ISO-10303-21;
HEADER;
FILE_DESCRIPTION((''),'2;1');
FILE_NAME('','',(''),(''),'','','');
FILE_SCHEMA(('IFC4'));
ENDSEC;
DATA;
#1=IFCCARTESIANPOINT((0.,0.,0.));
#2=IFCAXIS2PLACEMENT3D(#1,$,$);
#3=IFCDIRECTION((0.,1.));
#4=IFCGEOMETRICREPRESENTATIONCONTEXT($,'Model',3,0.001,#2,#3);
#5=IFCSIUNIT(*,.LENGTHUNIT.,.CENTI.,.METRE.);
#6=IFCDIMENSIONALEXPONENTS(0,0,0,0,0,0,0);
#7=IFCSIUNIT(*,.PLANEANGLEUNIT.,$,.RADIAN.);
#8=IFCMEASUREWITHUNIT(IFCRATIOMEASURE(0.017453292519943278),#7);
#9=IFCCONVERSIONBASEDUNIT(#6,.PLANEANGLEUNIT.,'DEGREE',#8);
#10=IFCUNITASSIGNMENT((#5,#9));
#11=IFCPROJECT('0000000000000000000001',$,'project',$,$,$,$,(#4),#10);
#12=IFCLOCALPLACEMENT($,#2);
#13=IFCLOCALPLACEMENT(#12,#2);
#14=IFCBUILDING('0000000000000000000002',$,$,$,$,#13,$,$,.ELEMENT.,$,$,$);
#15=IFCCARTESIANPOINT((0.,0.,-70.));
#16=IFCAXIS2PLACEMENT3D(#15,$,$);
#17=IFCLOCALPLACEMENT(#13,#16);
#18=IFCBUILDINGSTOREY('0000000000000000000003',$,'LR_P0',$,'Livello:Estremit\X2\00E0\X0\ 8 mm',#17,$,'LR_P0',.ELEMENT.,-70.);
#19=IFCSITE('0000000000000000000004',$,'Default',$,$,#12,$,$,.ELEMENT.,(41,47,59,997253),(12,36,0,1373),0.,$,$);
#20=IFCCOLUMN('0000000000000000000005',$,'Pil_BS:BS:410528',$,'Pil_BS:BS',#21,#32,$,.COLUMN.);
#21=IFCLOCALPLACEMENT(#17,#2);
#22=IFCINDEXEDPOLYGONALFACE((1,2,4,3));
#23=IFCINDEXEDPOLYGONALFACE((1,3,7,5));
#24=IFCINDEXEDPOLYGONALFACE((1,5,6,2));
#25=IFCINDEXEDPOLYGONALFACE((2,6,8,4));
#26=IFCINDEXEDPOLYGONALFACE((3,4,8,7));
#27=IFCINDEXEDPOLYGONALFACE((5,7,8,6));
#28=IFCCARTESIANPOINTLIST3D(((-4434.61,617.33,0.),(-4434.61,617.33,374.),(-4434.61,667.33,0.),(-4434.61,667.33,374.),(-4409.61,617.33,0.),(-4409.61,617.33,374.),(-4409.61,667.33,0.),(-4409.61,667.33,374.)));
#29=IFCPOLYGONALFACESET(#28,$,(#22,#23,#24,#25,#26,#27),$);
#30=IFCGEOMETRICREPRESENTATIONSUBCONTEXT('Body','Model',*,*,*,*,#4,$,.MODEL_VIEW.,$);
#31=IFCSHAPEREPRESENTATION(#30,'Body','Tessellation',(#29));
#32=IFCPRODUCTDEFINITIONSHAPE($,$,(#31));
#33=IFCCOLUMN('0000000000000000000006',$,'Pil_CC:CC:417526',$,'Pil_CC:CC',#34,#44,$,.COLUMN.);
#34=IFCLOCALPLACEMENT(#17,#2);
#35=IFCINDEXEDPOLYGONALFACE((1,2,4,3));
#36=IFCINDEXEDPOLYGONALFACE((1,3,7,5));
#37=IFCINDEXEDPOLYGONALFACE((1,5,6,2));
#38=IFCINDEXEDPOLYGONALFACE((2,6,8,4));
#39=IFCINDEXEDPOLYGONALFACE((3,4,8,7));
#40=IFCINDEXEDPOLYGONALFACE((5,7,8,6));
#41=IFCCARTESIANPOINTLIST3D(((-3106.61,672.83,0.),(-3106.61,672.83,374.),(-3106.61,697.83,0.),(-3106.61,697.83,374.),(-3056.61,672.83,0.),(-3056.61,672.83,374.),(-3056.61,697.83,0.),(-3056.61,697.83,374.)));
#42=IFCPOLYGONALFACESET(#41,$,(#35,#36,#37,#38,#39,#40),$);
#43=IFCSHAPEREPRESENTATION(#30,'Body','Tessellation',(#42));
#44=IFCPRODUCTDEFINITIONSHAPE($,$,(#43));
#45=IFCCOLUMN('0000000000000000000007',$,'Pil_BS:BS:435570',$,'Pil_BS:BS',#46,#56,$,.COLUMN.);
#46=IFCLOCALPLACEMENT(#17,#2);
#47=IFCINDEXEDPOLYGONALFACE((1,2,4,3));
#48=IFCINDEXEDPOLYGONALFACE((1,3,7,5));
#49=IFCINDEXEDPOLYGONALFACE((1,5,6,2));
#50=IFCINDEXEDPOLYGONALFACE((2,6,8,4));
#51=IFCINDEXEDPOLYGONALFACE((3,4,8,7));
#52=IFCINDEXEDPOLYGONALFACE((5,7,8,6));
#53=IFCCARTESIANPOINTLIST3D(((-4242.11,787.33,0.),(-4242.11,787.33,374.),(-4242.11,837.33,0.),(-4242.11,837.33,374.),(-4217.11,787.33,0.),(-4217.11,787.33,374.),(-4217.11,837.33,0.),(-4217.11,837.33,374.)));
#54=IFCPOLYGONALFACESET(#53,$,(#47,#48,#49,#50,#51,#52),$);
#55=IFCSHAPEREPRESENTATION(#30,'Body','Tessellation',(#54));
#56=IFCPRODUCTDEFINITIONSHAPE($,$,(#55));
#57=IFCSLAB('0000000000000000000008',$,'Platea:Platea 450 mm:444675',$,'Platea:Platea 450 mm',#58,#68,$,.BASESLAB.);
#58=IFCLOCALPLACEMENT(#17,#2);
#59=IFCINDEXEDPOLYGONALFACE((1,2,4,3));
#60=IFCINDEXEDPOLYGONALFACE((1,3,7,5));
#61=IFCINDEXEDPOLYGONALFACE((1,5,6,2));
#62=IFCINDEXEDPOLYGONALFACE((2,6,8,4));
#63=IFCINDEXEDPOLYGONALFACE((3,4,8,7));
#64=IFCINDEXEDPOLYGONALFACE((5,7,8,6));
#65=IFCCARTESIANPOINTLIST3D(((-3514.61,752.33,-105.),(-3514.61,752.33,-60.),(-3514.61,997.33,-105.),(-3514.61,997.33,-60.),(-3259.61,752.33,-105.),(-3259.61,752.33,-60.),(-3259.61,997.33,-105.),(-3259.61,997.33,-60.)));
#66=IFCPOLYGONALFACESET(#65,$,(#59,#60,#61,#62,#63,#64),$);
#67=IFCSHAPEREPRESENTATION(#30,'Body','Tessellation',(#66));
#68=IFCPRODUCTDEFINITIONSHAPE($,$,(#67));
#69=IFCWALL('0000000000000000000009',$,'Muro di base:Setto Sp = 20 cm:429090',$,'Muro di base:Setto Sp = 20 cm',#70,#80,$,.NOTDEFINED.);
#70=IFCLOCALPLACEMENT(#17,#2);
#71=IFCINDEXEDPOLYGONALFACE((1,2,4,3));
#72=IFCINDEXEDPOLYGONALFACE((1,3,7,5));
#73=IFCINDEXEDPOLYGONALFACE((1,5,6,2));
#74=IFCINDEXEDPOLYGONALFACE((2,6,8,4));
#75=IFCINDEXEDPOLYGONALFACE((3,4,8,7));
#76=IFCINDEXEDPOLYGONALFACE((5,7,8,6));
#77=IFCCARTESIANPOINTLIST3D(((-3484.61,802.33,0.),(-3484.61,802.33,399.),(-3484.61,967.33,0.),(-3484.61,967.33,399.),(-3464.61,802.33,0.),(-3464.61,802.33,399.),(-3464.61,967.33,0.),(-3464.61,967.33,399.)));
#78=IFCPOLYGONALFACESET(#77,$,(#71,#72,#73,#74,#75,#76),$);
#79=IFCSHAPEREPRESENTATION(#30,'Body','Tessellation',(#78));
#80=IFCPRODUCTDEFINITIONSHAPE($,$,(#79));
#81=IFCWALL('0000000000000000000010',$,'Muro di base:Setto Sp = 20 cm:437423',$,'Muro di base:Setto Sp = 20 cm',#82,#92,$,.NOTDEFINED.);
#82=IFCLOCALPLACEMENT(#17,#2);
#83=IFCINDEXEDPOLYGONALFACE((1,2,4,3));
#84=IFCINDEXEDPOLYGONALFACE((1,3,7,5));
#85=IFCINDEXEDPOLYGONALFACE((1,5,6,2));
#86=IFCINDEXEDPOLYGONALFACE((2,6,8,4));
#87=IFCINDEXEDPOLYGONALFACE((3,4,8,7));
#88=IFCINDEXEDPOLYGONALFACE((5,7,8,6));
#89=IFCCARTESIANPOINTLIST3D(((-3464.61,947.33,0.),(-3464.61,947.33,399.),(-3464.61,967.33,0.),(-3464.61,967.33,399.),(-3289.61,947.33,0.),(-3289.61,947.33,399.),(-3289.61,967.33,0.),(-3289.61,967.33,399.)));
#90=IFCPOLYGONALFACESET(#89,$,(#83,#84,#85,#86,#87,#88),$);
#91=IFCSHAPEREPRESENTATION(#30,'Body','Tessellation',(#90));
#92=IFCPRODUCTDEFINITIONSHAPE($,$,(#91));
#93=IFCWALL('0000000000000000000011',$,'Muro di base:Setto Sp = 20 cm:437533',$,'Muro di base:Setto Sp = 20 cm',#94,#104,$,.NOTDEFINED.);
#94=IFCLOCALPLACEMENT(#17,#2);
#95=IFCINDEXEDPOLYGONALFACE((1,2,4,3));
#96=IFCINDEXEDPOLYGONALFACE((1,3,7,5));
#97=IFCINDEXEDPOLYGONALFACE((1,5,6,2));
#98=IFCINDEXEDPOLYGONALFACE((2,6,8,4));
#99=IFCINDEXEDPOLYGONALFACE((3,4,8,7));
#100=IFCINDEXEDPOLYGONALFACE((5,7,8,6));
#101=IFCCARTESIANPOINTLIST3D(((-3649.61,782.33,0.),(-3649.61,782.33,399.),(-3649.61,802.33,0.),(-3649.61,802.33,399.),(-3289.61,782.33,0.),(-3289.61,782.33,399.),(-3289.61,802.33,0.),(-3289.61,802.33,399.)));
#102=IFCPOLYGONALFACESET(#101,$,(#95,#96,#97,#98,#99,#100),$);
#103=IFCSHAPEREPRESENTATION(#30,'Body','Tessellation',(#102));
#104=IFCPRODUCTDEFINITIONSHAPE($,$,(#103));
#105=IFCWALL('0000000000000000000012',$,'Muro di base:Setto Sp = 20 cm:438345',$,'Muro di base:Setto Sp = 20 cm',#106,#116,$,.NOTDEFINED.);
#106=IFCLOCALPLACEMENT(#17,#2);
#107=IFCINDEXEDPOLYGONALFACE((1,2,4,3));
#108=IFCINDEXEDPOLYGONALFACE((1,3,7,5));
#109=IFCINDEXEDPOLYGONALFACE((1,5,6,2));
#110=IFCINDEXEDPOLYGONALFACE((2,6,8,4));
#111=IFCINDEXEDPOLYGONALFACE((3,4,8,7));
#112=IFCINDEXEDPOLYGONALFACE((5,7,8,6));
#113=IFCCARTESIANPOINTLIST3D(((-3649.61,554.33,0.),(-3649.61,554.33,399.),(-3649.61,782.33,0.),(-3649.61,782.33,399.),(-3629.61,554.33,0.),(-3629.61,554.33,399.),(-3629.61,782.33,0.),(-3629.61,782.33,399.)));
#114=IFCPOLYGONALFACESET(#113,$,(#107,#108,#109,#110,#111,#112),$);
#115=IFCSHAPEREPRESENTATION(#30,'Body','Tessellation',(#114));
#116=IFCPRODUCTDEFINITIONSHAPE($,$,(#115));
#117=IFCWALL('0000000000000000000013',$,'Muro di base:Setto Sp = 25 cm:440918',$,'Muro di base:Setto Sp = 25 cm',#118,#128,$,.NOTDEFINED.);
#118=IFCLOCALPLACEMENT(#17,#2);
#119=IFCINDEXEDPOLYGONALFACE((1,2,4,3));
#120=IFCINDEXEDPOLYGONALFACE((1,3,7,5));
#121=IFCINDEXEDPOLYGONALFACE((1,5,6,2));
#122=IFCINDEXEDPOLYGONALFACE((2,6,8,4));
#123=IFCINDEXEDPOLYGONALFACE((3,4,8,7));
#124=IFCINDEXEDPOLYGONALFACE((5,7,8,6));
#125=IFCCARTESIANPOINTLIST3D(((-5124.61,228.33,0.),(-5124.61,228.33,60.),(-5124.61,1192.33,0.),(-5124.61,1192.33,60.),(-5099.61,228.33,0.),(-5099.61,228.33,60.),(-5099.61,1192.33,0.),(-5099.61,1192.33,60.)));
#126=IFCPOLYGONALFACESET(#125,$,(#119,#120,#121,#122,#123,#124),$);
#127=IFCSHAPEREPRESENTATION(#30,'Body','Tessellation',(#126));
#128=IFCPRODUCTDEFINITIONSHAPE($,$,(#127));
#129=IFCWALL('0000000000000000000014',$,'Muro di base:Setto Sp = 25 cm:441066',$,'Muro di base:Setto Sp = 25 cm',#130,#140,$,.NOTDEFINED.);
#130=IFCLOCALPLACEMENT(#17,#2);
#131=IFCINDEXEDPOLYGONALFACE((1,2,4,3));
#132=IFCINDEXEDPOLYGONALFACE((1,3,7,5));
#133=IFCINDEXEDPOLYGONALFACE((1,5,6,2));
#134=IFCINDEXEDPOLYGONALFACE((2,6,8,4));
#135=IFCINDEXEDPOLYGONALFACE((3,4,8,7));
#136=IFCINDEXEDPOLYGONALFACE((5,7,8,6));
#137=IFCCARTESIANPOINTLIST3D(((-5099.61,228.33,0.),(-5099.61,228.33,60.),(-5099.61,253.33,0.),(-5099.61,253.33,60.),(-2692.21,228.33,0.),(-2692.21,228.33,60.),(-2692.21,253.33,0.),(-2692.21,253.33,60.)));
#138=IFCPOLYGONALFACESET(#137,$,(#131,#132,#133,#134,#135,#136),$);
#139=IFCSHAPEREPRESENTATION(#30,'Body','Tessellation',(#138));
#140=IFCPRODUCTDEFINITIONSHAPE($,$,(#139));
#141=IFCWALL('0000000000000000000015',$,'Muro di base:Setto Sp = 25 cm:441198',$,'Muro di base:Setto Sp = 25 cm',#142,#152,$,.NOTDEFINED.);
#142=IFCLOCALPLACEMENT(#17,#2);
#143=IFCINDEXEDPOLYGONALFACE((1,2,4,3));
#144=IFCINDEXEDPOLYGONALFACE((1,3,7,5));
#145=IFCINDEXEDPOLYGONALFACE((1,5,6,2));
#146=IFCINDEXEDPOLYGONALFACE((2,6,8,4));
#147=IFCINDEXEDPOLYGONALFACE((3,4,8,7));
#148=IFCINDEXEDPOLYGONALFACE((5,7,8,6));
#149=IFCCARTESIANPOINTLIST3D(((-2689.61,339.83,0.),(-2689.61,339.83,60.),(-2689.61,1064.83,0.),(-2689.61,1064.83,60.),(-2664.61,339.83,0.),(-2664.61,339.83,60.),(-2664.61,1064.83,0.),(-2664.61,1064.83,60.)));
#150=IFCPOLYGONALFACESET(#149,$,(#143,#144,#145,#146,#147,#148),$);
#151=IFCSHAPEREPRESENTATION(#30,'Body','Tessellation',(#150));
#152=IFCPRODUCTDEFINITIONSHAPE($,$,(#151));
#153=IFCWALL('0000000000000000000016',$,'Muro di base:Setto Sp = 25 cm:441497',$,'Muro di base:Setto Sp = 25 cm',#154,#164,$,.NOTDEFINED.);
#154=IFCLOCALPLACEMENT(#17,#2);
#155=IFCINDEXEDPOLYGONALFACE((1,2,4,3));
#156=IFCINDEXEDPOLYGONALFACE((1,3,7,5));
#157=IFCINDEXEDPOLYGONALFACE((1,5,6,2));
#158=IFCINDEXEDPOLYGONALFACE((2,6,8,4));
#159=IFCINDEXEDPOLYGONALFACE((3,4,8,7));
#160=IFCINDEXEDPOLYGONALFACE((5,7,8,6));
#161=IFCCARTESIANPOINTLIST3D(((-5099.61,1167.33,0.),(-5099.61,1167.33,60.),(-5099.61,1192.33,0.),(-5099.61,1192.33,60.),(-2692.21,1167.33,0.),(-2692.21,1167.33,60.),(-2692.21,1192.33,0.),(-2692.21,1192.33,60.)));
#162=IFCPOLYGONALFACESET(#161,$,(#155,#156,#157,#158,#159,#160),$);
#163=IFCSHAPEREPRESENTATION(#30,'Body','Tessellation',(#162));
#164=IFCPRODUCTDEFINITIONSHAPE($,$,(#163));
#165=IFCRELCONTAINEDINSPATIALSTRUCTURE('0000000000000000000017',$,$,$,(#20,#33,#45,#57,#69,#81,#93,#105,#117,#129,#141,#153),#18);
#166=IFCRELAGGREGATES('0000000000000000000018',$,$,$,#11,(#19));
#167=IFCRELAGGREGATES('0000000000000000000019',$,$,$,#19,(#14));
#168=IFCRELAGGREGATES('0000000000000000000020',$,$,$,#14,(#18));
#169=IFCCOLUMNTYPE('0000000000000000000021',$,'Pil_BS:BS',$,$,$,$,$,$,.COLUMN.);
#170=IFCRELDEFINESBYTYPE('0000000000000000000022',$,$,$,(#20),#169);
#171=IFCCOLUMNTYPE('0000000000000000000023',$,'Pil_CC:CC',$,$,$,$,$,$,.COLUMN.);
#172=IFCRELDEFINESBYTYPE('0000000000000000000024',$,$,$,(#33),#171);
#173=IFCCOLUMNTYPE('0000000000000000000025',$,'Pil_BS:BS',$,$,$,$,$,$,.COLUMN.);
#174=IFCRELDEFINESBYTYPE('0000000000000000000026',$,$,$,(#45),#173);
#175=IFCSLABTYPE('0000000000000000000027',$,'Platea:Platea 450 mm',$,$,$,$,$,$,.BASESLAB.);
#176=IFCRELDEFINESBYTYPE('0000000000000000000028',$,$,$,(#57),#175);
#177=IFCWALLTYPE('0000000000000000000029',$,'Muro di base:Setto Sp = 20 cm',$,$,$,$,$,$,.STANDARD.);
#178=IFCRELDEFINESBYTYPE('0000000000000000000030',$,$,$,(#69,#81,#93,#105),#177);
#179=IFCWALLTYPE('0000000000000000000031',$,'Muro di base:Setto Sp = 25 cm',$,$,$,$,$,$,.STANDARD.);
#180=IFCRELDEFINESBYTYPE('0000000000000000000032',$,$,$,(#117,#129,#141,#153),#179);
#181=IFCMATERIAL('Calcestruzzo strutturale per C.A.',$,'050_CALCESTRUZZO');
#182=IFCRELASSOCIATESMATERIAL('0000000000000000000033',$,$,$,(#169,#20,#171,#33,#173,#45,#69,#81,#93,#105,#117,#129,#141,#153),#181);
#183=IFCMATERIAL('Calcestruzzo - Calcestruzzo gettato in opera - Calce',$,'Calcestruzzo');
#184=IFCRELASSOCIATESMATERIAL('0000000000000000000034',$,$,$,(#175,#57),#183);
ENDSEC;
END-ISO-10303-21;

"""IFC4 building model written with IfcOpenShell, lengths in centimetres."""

from ifc_helpers import new_model, entity, si_unit, converted_unit, direction, frame, origin, place, context, subcontext, project, spatial, indexed_curve, outline, extrude, source, transform, mapped, material, type_object, type_shapes, element, save


model = new_model("IFC4")

# Units and contexts
model_context = context("Model", 3, precision=0.001, world=origin(), true_north=direction((0.0, 1.0)))
body_context = subcontext(model_context, "Body", "Model", "MODEL_VIEW")
ifc_project = project(units=[si_unit("LENGTHUNIT", "METRE", prefix="CENTI"), converted_unit("PLANEANGLEUNIT", "DEGREE", entity("IfcRatioMeasure", 0.017453292519943278), si_unit("PLANEANGLEUNIT", "RADIAN"), dimensions=[0, 0, 0, 0, 0, 0, 0])], contexts=[model_context])

# Site, building, storey
site_placement = place(None, origin())
site = spatial("IfcSite", under=ifc_project, at=site_placement, Name="Default", CompositionType="ELEMENT", RefLatitude=(41, 47, 59, 997253), RefLongitude=(12, 36, 0, 1373), RefElevation=0.0)
building_placement = place(site_placement, origin())
building = spatial("IfcBuilding", under=site, at=building_placement, CompositionType="ELEMENT")
storey_placement = place(building_placement, frame((0.0, 0.0, -70.0)))
storey = spatial("IfcBuildingStorey", under=building, at=storey_placement, Name="LR_P0", ObjectType="Livello:Estremità 8 mm", LongName="LR_P0", CompositionType="ELEMENT", Elevation=-70.0)

# Columns
ifc_material_1 = material(Name="Calcestruzzo strutturale per C.A.", Category="050_CALCESTRUZZO")
column_type_1 = type_object("IfcColumnType", Name="Pil_BS:BS", PredefinedType="COLUMN", material=ifc_material_1)
shared_shape_1 = source(origin(), body_context, "Body", "SweptSolid", [
    extrude(outline(indexed_curve([(-25.0, -12.5), (25.0, -12.5), (25.0, 12.5), (-25.0, 12.5), (-25.0, -12.5)], self_intersect=False)), frame((-4422.11, 642.33, -70.0), z_axis=(0.0, 0.0, 1.0), x_axis=(0.0, -1.0, 0.0)), (0.0, 0.0, 1.0), 374.0),
])
type_shapes(column_type_1, [shared_shape_1])
column_1_placement = place(storey_placement, frame((0.0, 0.0, 70.0)))
element("IfcColumn", 1, at=column_1_placement, inside=storey, type_object=column_type_1, material=ifc_material_1, Name="Pil_BS:BS:410528", ObjectType="Pil_BS:BS", PredefinedType="COLUMN", context=body_context, shape_type="MappedRepresentation", body=[
    mapped(shared_shape_1, transform((0.0, 0.0, 0.0), scale=1.0)),
])
column_type_2 = type_object("IfcColumnType", Name="Pil_CC:CC", PredefinedType="COLUMN", material=ifc_material_1)
shared_shape_2 = source(origin(), body_context, "Body", "SweptSolid", [
    extrude(outline(indexed_curve([(-12.5, -25.0), (12.5, -25.0), (12.5, 25.0), (-12.5, 25.0), (-12.5, -25.0)], self_intersect=False)), frame((-3081.61, 685.33, -70.0), z_axis=(0.0, 0.0, 1.0), x_axis=(0.0, -1.0, 0.0)), (0.0, 0.0, 1.0), 374.0),
])
type_shapes(column_type_2, [shared_shape_2])
column_2_placement = place(storey_placement, frame((0.0, 0.0, 70.0)))
element("IfcColumn", 2, at=column_2_placement, inside=storey, type_object=column_type_2, material=ifc_material_1, Name="Pil_CC:CC:417526", ObjectType="Pil_CC:CC", PredefinedType="COLUMN", context=body_context, shape_type="MappedRepresentation", body=[
    mapped(shared_shape_2, transform((0.0, 0.0, 0.0), scale=1.0)),
])
column_type_3 = type_object("IfcColumnType", Name="Pil_BS:BS", PredefinedType="COLUMN", material=ifc_material_1)
shared_shape_3 = source(origin(), body_context, "Body", "SweptSolid", [
    extrude(outline(indexed_curve([(-25.0, -12.5), (25.0, -12.5), (25.0, 12.5), (-25.0, 12.5), (-25.0, -12.5)], self_intersect=False)), frame((-4229.61, 812.33, -70.0), z_axis=(0.0, 0.0, 1.0), x_axis=(0.0, -1.0, 0.0)), (0.0, 0.0, 1.0), 374.0),
])
type_shapes(column_type_3, [shared_shape_3])
column_3_placement = place(storey_placement, frame((0.0, 0.0, 70.0)))
element("IfcColumn", 3, at=column_3_placement, inside=storey, type_object=column_type_3, material=ifc_material_1, Name="Pil_BS:BS:435570", ObjectType="Pil_BS:BS", PredefinedType="COLUMN", context=body_context, shape_type="MappedRepresentation", body=[
    mapped(shared_shape_3, transform((0.0, 0.0, 0.0), scale=1.0)),
])

# Slab
ifc_material_2 = material(Name="Calcestruzzo - Calcestruzzo gettato in opera - Calce", Category="Calcestruzzo")
slab_type_1 = type_object("IfcSlabType", Name="Platea:Platea 450 mm", PredefinedType="BASESLAB", material=ifc_material_2)
slab_1_placement = place(storey_placement, origin())
element("IfcSlab", 4, at=slab_1_placement, inside=storey, type_object=slab_type_1, material=ifc_material_2, Name="Platea:Platea 450 mm:444675", ObjectType="Platea:Platea 450 mm", PredefinedType="BASESLAB", context=body_context, shape_type="SweptSolid", body=[
    extrude(outline(indexed_curve([(-122.5, -127.5), (122.5, -127.5), (122.5, 127.5), (-122.5, 127.5), (-122.5, -127.5)], self_intersect=False)), frame((-3387.11, 874.83, -60.0), z_axis=(0.0, 0.0, -1.0), x_axis=(0.0, 1.0, 0.0)), (0.0, 0.0, 1.0), 45.0),
])

# Walls
wall_type_1 = type_object("IfcWallType", Name="Muro di base:Setto Sp = 20 cm", PredefinedType="STANDARD")
wall_1_placement = place(storey_placement, frame((-3474.61, 802.33, 0.0), z_axis=(0.0, 0.0, 1.0), x_axis=(0.0, 1.0, 0.0)))
element("IfcWall", 5, at=wall_1_placement, inside=storey, type_object=wall_type_1, material=ifc_material_1, Name="Muro di base:Setto Sp = 20 cm:429090", ObjectType="Muro di base:Setto Sp = 20 cm", PredefinedType="NOTDEFINED", context=body_context, shape_type="SweptSolid", body=[
    extrude(outline(indexed_curve([(165.0, 10.0), (0.0, 10.0), (0.0, -10.0), (165.0, -10.0), (165.0, 10.0)], self_intersect=False)), origin(), (0.0, 0.0, 1.0), 399.0),
])
wall_2_placement = place(storey_placement, frame((-3464.61, 957.33, 0.0)))
element("IfcWall", 6, at=wall_2_placement, inside=storey, type_object=wall_type_1, material=ifc_material_1, Name="Muro di base:Setto Sp = 20 cm:437423", ObjectType="Muro di base:Setto Sp = 20 cm", PredefinedType="NOTDEFINED", context=body_context, shape_type="SweptSolid", body=[
    extrude(outline(indexed_curve([(175.0, 10.0), (0.0, 10.0), (0.0, -10.0), (175.0, -10.0), (175.0, 10.0)], self_intersect=False)), origin(), (0.0, 0.0, 1.0), 399.0),
])
wall_3_placement = place(storey_placement, frame((-3649.61, 792.33, 0.0)))
element("IfcWall", 7, at=wall_3_placement, inside=storey, type_object=wall_type_1, material=ifc_material_1, Name="Muro di base:Setto Sp = 20 cm:437533", ObjectType="Muro di base:Setto Sp = 20 cm", PredefinedType="NOTDEFINED", context=body_context, shape_type="SweptSolid", body=[
    extrude(outline(indexed_curve([(360.0, 10.0), (0.0, 10.0), (0.0, -10.0), (360.0, -10.0), (360.0, 10.0)], self_intersect=False)), origin(), (0.0, 0.0, 1.0), 399.0),
])
wall_4_placement = place(storey_placement, frame((-3639.61, 554.33, 0.0), z_axis=(0.0, 0.0, 1.0), x_axis=(0.0, 1.0, 0.0)))
element("IfcWall", 8, at=wall_4_placement, inside=storey, type_object=wall_type_1, material=ifc_material_1, Name="Muro di base:Setto Sp = 20 cm:438345", ObjectType="Muro di base:Setto Sp = 20 cm", PredefinedType="NOTDEFINED", context=body_context, shape_type="SweptSolid", body=[
    extrude(outline(indexed_curve([(228.0, 10.0), (0.0, 10.0), (0.0, -10.0), (228.0, -10.0), (228.0, 10.0)], self_intersect=False)), origin(), (0.0, 0.0, 1.0), 399.0),
])
wall_type_2 = type_object("IfcWallType", Name="Muro di base:Setto Sp = 25 cm", PredefinedType="STANDARD")
wall_5_placement = place(storey_placement, frame((-5112.11, 1192.33, 0.0), z_axis=(0.0, 0.0, 1.0), x_axis=(0.0, -1.0, 0.0)))
element("IfcWall", 9, at=wall_5_placement, inside=storey, type_object=wall_type_2, material=ifc_material_1, Name="Muro di base:Setto Sp = 25 cm:440918", ObjectType="Muro di base:Setto Sp = 25 cm", PredefinedType="NOTDEFINED", context=body_context, shape_type="SweptSolid", body=[
    extrude(outline(indexed_curve([(964.0, 12.5), (0.0, 12.5), (0.0, -12.5), (964.0, -12.5), (964.0, 12.5)], self_intersect=False)), origin(), (0.0, 0.0, 1.0), 60.0),
])
wall_6_placement = place(storey_placement, frame((-5099.61, 240.83, 0.0)))
element("IfcWall", 10, at=wall_6_placement, inside=storey, type_object=wall_type_2, material=ifc_material_1, Name="Muro di base:Setto Sp = 25 cm:441066", ObjectType="Muro di base:Setto Sp = 25 cm", PredefinedType="NOTDEFINED", context=body_context, shape_type="SweptSolid", body=[
    extrude(outline(indexed_curve([(2407.4, 12.5), (0.0, 12.5), (0.0, -12.5), (2407.4, -12.5), (2407.4, 12.5)], self_intersect=False)), origin(), (0.0, 0.0, 1.0), 60.0),
])
wall_7_placement = place(storey_placement, frame((-2677.11, 339.83, 0.0), z_axis=(0.0, 0.0, 1.0), x_axis=(0.0, 1.0, 0.0)))
element("IfcWall", 11, at=wall_7_placement, inside=storey, type_object=wall_type_2, material=ifc_material_1, Name="Muro di base:Setto Sp = 25 cm:441198", ObjectType="Muro di base:Setto Sp = 25 cm", PredefinedType="NOTDEFINED", context=body_context, shape_type="SweptSolid", body=[
    extrude(outline(indexed_curve([(725.0, 12.5), (0.0, 12.5), (0.0, -12.5), (725.0, -12.5), (725.0, 12.5)], self_intersect=False)), origin(), (0.0, 0.0, 1.0), 60.0),
])
wall_8_placement = place(storey_placement, frame((-2692.21, 1179.83, 0.0), z_axis=(0.0, 0.0, 1.0), x_axis=(-1.0, 0.0, 0.0)))
element("IfcWall", 12, at=wall_8_placement, inside=storey, type_object=wall_type_2, material=ifc_material_1, Name="Muro di base:Setto Sp = 25 cm:441497", ObjectType="Muro di base:Setto Sp = 25 cm", PredefinedType="NOTDEFINED", context=body_context, shape_type="SweptSolid", body=[
    extrude(outline(indexed_curve([(2407.4, 12.5), (0.0, 12.5), (0.0, -12.5), (2407.4, -12.5), (2407.4, 12.5)], self_intersect=False)), origin(), (0.0, 0.0, 1.0), 60.0),
])

save(model, "model.ifc")
